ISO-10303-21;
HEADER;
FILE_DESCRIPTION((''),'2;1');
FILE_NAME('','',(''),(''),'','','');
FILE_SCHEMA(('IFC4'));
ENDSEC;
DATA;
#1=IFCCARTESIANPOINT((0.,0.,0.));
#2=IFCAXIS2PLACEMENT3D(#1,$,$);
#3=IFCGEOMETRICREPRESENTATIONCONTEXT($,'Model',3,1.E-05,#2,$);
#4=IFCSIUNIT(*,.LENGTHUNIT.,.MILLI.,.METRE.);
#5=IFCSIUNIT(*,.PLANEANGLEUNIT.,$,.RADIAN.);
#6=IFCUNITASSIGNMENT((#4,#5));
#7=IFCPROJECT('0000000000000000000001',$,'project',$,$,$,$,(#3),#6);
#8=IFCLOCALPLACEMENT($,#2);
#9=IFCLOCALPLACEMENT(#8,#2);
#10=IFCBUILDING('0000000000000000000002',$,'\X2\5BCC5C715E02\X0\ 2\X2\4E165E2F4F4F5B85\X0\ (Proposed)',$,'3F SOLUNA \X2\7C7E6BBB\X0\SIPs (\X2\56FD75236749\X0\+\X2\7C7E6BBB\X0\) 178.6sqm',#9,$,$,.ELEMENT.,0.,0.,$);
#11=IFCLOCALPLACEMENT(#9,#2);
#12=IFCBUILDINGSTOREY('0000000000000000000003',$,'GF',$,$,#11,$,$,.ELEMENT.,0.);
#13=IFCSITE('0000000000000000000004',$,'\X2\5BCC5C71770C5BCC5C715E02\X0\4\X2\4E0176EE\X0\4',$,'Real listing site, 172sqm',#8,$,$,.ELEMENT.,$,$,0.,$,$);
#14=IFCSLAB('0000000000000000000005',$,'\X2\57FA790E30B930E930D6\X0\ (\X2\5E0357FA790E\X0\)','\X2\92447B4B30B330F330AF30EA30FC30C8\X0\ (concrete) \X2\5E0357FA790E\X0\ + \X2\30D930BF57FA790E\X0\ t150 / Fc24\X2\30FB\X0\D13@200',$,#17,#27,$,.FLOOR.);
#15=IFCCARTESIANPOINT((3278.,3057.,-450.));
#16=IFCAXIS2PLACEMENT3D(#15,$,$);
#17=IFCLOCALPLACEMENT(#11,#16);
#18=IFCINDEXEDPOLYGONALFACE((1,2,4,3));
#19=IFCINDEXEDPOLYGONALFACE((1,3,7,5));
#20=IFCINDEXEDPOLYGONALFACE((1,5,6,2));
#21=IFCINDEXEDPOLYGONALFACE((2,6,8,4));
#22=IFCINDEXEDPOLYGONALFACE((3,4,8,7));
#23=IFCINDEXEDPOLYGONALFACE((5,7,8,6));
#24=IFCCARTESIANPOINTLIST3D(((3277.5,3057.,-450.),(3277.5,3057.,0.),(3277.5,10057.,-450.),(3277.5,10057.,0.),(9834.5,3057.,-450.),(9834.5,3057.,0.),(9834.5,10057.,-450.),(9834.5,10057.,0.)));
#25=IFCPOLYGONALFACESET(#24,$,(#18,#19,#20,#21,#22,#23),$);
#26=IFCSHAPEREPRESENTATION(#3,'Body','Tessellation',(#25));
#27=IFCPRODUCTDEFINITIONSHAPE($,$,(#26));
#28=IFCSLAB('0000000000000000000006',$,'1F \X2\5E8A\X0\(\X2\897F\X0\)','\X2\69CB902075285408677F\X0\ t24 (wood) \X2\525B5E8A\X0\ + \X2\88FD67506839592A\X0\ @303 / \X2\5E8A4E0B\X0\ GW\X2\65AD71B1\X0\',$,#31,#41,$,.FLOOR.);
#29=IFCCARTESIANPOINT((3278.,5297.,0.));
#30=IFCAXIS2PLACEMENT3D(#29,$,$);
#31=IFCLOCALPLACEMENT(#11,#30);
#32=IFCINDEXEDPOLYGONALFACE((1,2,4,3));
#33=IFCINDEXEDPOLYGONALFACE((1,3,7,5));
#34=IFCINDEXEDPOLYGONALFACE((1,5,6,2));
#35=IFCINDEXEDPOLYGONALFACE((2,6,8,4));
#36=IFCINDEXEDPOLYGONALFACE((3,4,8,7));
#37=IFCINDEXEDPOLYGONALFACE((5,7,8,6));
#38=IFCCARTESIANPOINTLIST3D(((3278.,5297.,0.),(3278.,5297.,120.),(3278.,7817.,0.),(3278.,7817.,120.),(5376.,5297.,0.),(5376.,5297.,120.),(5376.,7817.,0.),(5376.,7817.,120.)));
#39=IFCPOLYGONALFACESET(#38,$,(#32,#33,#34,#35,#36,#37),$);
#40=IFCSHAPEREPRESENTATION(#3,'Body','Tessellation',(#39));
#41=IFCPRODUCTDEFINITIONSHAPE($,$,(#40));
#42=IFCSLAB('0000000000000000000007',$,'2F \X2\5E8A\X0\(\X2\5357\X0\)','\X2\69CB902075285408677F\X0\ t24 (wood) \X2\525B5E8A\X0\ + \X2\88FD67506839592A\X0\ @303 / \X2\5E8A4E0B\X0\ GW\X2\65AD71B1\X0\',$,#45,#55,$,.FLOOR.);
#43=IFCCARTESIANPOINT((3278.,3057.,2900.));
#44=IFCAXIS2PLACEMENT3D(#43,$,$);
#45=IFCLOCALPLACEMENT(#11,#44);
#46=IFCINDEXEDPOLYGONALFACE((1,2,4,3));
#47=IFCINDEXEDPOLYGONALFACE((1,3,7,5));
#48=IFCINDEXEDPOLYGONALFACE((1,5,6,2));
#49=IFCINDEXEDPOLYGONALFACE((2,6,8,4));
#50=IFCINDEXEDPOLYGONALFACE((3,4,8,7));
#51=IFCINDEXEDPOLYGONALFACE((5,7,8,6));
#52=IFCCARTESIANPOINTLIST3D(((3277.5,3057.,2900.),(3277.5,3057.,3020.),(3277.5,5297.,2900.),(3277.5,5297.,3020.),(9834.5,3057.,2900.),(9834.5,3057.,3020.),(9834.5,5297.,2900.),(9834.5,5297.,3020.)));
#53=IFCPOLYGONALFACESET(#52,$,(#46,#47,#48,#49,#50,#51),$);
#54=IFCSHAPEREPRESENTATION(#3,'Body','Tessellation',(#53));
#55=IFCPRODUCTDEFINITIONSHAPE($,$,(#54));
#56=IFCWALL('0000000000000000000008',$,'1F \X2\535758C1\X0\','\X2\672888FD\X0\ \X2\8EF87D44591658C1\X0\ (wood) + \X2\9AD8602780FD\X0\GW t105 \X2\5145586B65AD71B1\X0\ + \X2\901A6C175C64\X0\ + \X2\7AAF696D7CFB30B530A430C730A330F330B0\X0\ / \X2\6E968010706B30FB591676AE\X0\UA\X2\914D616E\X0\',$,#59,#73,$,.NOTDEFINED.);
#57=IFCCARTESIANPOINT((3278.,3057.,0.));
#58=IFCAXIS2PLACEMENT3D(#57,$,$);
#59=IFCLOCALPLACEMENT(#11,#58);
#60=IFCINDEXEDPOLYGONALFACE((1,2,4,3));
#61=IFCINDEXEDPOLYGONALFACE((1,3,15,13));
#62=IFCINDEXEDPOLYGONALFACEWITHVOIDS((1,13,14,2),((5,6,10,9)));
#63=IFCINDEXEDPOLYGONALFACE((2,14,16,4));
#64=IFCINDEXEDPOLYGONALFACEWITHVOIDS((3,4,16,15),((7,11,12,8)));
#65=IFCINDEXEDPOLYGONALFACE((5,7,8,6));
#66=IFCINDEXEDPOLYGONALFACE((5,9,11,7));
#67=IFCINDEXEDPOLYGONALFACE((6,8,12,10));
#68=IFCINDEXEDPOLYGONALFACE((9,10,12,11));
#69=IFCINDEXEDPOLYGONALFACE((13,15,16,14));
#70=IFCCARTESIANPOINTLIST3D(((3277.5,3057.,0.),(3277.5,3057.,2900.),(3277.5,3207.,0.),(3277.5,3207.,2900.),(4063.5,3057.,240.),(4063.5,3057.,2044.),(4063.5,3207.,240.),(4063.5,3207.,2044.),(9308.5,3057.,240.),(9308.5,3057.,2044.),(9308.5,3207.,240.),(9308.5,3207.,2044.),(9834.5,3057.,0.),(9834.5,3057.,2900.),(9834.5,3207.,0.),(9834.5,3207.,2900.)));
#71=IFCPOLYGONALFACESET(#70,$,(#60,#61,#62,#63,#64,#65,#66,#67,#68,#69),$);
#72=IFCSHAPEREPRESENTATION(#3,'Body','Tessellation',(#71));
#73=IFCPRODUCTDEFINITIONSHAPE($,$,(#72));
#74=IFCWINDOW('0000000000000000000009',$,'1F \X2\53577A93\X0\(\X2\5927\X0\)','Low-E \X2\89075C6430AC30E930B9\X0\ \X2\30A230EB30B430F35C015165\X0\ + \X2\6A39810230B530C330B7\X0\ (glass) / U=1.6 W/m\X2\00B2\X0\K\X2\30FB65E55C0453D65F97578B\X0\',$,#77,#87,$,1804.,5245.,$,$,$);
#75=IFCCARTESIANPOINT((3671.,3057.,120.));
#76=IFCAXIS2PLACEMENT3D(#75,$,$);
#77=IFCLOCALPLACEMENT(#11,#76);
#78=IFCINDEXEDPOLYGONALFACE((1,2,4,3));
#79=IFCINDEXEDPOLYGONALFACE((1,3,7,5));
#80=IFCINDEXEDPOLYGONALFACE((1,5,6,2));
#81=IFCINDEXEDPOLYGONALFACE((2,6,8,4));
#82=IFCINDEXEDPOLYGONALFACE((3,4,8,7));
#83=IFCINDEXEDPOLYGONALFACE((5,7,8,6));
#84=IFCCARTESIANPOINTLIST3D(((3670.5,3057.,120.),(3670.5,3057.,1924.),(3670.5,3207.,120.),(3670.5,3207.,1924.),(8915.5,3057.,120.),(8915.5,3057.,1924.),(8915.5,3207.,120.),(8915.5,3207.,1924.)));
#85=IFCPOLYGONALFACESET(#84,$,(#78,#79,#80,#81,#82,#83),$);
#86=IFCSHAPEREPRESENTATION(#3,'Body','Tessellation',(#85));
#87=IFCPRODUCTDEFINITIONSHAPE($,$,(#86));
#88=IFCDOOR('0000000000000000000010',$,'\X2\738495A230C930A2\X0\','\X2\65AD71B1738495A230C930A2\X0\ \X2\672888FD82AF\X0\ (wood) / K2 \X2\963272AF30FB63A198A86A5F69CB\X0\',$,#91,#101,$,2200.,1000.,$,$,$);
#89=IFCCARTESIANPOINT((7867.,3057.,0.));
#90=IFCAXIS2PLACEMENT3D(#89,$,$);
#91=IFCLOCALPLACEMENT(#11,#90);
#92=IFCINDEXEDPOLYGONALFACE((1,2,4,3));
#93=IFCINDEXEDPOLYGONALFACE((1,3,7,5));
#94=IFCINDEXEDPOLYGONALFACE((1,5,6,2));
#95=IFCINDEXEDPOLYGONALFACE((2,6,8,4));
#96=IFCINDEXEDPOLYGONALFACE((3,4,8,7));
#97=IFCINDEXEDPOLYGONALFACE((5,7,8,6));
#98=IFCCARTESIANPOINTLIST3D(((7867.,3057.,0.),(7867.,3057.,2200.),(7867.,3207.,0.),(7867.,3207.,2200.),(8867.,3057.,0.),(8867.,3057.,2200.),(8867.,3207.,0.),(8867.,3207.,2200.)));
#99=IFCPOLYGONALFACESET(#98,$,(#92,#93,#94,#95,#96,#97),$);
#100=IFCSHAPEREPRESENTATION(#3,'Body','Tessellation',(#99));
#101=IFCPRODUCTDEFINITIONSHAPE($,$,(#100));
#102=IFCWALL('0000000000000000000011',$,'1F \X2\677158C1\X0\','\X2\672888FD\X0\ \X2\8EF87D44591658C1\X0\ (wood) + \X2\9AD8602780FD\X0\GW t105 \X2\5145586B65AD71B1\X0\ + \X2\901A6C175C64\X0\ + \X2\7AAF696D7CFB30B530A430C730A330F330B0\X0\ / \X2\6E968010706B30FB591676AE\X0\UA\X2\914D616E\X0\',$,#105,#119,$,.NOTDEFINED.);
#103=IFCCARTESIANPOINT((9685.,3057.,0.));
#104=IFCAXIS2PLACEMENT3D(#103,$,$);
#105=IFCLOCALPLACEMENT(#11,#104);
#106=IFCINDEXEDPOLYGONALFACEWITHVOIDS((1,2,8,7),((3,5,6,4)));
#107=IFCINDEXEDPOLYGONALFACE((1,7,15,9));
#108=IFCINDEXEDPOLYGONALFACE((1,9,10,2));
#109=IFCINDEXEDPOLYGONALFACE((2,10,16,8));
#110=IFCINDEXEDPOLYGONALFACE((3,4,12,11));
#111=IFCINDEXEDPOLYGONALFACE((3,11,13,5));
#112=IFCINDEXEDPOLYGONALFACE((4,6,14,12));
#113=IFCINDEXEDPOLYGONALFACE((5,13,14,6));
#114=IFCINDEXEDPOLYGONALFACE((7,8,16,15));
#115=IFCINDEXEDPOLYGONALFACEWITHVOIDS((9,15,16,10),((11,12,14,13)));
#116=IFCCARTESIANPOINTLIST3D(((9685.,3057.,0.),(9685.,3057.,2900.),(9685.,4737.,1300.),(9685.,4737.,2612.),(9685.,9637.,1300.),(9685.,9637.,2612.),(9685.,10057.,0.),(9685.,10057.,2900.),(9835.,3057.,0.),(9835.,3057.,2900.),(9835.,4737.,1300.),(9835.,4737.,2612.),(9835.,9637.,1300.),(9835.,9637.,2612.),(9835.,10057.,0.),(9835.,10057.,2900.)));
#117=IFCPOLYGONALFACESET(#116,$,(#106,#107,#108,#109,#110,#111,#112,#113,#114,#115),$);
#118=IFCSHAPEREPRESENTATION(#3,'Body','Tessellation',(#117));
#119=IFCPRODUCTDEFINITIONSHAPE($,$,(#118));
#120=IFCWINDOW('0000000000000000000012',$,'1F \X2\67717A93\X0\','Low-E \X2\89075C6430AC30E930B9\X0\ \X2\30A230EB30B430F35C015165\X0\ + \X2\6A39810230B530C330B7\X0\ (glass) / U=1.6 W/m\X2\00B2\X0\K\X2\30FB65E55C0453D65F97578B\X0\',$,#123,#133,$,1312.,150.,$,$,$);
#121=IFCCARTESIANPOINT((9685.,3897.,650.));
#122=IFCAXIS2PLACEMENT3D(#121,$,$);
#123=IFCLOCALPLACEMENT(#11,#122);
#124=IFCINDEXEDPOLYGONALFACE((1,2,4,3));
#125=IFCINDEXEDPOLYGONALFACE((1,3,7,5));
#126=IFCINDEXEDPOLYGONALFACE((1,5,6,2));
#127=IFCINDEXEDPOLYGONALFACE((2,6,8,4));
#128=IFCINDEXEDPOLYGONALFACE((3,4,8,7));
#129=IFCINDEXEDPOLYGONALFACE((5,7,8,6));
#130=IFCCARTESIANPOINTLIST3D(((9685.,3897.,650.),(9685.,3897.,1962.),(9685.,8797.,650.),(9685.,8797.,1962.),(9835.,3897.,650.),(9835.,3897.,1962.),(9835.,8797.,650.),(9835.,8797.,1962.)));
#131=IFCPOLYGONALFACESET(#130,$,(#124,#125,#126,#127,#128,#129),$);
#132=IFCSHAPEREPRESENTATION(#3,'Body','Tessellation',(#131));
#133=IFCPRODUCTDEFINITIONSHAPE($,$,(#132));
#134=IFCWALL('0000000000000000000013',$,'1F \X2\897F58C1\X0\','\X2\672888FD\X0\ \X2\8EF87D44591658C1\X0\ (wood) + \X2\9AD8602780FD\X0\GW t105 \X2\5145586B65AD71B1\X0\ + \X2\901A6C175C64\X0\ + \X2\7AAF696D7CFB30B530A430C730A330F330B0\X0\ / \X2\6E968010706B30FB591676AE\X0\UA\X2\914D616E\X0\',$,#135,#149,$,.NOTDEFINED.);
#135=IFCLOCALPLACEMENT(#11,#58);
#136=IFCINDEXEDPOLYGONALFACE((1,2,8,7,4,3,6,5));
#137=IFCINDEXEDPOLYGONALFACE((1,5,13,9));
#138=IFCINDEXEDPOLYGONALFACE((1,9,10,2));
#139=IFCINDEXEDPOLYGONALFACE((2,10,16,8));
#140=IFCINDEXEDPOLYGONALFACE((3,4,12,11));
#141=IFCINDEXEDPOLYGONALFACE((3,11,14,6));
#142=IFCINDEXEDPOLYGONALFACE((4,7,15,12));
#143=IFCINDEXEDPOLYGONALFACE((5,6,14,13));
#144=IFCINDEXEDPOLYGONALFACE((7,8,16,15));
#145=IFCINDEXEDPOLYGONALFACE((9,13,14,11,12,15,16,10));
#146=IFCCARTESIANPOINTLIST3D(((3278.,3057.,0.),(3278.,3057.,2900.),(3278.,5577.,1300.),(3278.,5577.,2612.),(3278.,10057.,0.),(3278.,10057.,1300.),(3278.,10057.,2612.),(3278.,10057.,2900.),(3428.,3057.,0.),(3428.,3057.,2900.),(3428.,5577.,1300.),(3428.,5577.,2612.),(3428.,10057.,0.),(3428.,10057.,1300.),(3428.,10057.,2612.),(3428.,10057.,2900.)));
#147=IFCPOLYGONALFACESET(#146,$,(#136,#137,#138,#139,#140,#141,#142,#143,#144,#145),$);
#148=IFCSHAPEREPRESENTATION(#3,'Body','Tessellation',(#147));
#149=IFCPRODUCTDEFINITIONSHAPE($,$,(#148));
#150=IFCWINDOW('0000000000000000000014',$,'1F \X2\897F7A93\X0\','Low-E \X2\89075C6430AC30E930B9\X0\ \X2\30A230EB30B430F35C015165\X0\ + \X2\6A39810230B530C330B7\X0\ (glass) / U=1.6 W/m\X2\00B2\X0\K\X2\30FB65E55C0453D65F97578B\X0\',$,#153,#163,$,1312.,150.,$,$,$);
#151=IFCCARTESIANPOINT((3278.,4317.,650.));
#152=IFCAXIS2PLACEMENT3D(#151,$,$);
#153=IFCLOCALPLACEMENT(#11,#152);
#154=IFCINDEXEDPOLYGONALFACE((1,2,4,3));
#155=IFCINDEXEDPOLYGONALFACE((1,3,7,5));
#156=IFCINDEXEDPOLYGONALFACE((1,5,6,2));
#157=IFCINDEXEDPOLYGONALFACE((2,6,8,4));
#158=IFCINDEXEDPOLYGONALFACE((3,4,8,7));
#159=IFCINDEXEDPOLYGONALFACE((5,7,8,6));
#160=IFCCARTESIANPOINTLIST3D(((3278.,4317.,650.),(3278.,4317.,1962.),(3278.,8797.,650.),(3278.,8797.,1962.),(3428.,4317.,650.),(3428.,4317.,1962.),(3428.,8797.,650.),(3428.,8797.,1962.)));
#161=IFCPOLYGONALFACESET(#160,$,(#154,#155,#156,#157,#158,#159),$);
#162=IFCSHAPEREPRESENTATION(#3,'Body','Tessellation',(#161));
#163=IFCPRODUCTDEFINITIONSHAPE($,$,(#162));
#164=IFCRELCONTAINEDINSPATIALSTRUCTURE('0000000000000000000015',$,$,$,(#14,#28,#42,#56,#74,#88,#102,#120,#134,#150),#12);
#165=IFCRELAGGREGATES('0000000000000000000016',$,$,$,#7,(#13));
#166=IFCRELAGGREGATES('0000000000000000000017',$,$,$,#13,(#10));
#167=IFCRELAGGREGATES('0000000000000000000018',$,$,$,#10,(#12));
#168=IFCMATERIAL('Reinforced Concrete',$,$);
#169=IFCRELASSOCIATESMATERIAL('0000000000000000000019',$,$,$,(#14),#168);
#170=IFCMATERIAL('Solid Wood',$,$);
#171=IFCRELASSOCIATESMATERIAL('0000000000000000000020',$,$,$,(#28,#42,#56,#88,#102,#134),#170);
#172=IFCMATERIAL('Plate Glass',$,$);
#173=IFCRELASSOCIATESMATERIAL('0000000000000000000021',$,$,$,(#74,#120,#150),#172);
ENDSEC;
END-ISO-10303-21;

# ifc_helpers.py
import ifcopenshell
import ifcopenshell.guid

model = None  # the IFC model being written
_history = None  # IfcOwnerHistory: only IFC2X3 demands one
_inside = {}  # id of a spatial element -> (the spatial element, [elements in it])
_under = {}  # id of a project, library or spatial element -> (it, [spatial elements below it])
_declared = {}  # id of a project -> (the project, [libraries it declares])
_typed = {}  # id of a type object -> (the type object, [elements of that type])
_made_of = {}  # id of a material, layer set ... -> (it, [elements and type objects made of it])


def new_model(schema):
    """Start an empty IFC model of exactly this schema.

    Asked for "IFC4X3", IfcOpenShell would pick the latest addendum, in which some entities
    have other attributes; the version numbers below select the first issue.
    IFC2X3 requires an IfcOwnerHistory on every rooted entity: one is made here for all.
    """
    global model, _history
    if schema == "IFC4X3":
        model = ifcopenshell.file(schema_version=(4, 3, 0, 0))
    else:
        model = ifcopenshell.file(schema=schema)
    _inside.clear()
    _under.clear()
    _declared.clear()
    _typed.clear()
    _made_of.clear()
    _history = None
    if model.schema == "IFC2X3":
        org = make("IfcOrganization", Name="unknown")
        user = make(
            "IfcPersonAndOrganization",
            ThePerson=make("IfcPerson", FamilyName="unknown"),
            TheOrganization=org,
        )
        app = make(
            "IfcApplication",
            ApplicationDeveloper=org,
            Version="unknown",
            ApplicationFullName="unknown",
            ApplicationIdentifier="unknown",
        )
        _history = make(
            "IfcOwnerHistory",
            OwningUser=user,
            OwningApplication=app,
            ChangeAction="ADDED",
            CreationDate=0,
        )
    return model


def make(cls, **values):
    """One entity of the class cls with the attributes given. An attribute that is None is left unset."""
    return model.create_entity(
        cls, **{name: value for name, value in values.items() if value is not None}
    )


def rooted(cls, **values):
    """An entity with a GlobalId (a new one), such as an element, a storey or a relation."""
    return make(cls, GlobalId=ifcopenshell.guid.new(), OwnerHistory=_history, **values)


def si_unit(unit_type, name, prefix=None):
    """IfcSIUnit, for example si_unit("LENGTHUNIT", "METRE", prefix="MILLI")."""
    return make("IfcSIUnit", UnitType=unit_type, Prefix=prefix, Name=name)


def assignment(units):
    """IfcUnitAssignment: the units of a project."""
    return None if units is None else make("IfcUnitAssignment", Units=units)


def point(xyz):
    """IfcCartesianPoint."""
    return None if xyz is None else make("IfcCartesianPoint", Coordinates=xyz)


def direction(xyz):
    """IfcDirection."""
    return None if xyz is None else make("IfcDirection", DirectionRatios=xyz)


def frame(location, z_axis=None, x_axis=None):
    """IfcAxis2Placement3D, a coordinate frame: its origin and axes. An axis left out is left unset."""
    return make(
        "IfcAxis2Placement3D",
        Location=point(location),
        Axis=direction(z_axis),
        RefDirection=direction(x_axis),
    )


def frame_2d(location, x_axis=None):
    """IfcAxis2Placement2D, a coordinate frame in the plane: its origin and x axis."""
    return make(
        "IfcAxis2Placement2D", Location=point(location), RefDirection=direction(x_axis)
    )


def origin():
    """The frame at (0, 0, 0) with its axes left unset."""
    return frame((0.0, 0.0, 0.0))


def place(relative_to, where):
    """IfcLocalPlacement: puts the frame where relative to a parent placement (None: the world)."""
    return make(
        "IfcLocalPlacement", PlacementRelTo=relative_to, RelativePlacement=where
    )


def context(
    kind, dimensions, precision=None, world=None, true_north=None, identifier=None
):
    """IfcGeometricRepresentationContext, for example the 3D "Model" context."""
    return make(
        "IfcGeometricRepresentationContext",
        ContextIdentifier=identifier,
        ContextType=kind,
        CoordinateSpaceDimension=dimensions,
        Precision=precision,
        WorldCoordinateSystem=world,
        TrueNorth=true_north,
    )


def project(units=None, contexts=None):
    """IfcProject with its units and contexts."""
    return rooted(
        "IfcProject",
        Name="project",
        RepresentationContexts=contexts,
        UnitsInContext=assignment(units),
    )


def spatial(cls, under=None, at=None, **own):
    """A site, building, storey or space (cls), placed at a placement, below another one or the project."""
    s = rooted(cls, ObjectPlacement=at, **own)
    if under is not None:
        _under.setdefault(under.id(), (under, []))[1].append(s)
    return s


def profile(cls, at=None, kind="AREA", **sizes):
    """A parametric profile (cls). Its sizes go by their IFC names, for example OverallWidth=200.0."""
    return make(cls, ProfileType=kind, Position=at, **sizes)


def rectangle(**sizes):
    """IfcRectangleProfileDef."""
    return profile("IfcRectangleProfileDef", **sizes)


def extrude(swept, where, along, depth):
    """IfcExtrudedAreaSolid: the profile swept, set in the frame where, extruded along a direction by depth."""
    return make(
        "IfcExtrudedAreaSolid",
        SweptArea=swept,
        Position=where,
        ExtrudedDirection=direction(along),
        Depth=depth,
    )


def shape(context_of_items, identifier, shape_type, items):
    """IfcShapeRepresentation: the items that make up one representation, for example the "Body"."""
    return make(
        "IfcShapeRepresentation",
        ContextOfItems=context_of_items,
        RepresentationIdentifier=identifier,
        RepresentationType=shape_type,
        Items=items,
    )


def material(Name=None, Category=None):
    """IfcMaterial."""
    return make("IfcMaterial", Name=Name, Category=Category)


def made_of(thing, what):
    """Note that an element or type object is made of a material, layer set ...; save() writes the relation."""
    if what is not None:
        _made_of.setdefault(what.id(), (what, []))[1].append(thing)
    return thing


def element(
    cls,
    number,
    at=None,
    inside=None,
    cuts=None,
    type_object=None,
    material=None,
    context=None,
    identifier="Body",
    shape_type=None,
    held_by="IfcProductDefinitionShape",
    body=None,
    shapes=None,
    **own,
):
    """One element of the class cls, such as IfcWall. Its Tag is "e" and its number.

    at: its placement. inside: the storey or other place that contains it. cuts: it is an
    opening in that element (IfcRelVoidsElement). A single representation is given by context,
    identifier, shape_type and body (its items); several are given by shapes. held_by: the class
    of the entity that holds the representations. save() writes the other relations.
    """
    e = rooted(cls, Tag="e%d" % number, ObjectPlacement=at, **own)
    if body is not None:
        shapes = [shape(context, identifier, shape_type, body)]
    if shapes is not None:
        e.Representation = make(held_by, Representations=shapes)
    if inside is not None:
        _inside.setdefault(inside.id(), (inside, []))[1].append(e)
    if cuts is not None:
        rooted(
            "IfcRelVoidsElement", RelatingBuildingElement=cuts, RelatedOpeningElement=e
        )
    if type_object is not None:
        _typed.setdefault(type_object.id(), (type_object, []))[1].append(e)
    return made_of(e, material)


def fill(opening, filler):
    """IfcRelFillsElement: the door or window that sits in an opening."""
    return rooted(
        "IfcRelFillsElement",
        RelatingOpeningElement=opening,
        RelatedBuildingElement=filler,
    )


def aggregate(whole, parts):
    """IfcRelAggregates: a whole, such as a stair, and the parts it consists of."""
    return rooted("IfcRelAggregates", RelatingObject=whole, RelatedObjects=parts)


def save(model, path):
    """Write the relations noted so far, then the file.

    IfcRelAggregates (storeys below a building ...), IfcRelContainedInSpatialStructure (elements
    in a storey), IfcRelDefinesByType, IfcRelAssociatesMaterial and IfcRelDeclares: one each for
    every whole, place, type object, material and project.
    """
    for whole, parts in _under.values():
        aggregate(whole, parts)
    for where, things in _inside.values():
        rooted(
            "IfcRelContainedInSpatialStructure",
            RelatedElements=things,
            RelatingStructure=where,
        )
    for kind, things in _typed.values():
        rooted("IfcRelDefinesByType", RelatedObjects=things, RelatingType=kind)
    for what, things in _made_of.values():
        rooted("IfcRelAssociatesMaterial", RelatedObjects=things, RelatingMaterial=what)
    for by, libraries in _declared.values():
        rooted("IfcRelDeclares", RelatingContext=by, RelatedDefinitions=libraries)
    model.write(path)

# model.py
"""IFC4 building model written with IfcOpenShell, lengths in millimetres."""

from ifc_helpers import new_model, si_unit, frame, frame_2d, origin, place, context, project, spatial, rectangle, extrude, material, element, fill, save


model = new_model("IFC4")

# Units and contexts
model_context = context("Model", 3, precision=1e-05, world=origin())
ifc_project = project(units=[si_unit("LENGTHUNIT", "METRE", prefix="MILLI"), si_unit("PLANEANGLEUNIT", "RADIAN")], contexts=[model_context])

# Site, building, storey
site_placement = place(None, origin())
site = spatial("IfcSite", under=ifc_project, at=site_placement, Name="富山県富山市4丁目4", ObjectType="Real listing site, 172sqm", CompositionType="ELEMENT", RefElevation=0.0)
building_placement = place(site_placement, origin())
building = spatial("IfcBuilding", under=site, at=building_placement, Name="富山市 2世帯住宅 (Proposed)", ObjectType="3F SOLUNA 籾殻SIPs (国産杉+籾殻) 178.6sqm", CompositionType="ELEMENT", ElevationOfRefHeight=0.0, ElevationOfTerrain=0.0)
storey_placement = place(building_placement, origin())
storey = spatial("IfcBuildingStorey", under=building, at=storey_placement, Name="GF", CompositionType="ELEMENT", Elevation=0.0)

# Slabs
ifc_material_1 = material(Name="Reinforced Concrete")
slab_1_placement = place(storey_placement, frame((3278.0, 3057.0, -450.0)))
element("IfcSlab", 1, at=slab_1_placement, inside=storey, material=ifc_material_1, Name="基礎スラブ (布基礎)", Description="鉄筋コンクリート (concrete) 布基礎 + ベタ基礎 t150 / Fc24・D13@200", PredefinedType="FLOOR", context=model_context, shape_type="SweptSolid", body=[
    extrude(rectangle(XDim=6557.0, YDim=7000.0, at=frame_2d((3278.0, 3500.0))), frame((3278.0, 3057.0, -450.0)), (0.0, 0.0, 1.0), 450.0),
])
ifc_material_2 = material(Name="Solid Wood")
slab_2_placement = place(storey_placement, frame((3278.0, 5297.0, 0.0)))
element("IfcSlab", 2, at=slab_2_placement, inside=storey, material=ifc_material_2, Name="1F 床(西)", Description="構造用合板 t24 (wood) 剛床 + 製材根太 @303 / 床下 GW断熱", PredefinedType="FLOOR", context=model_context, shape_type="SweptSolid", body=[
    extrude(rectangle(XDim=2098.0, YDim=2520.0, at=frame_2d((1049.0, 1260.0))), frame((3278.0, 5297.0, 0.0)), (0.0, 0.0, 1.0), 120.0),
])
slab_3_placement = place(storey_placement, frame((3278.0, 3057.0, 2900.0)))
element("IfcSlab", 3, at=slab_3_placement, inside=storey, material=ifc_material_2, Name="2F 床(南)", Description="構造用合板 t24 (wood) 剛床 + 製材根太 @303 / 床下 GW断熱", PredefinedType="FLOOR", context=model_context, shape_type="SweptSolid", body=[
    extrude(rectangle(XDim=6557.0, YDim=2240.0, at=frame_2d((3278.0, 1120.0))), frame((3278.0, 3057.0, 2900.0)), (0.0, 0.0, 1.0), 120.0),
])

# Wall, openings, window, door
wall_1_placement = place(storey_placement, frame((3278.0, 3057.0, 0.0)))
wall_1 = element("IfcWall", 4, at=wall_1_placement, inside=storey, material=ifc_material_2, Name="1F 南壁", Description="木製 軸組外壁 (wood) + 高性能GW t105 充填断熱 + 通気層 + 窯業系サイディング / 準耐火・外皮UA配慮", PredefinedType="NOTDEFINED", context=model_context, shape_type="SweptSolid", body=[
    extrude(rectangle(XDim=6557.0, YDim=150.0, at=frame_2d((3278.0, 75.0))), frame((3278.0, 3057.0, 0.0)), (0.0, 0.0, 1.0), 2900.0),
])
opening_1_placement = place(storey_placement, frame((3671.0, 3057.0, 120.0)))
opening_1 = element("IfcOpeningElement", 5, at=opening_1_placement, cuts=wall_1, PredefinedType="NOTDEFINED", context=model_context, shape_type="SweptSolid", body=[
    extrude(rectangle(XDim=5245.0, YDim=150.0, at=frame_2d((2622.0, 75.0))), frame((3671.0, 3057.0, 120.0)), (0.0, 0.0, 1.0), 1804.0),
])
opening_2_placement = place(storey_placement, frame((7867.0, 3057.0, 0.0)))
opening_2 = element("IfcOpeningElement", 6, at=opening_2_placement, cuts=wall_1, PredefinedType="NOTDEFINED", context=model_context, shape_type="SweptSolid", body=[
    extrude(rectangle(XDim=1000.0, YDim=150.0, at=frame_2d((500.0, 75.0))), frame((7867.0, 3057.0, 0.0)), (0.0, 0.0, 1.0), 2200.0),
])
ifc_material_3 = material(Name="Plate Glass")
window_1_placement = place(storey_placement, frame((3671.0, 3057.0, 120.0)))
window_1 = element("IfcWindow", 7, at=window_1_placement, inside=storey, material=ifc_material_3, Name="1F 南窓(大)", Description="Low-E 複層ガラス アルゴン封入 + 樹脂サッシ (glass) / U=1.6 W/m²K・日射取得型", OverallHeight=1804.0, OverallWidth=5245.0, context=model_context, shape_type="SweptSolid", body=[
    extrude(rectangle(XDim=5245.0, YDim=150.0, at=frame_2d((2622.0, 75.0))), frame((3671.0, 3057.0, 120.0)), (0.0, 0.0, 1.0), 1804.0),
])
fill(opening_1, window_1)
door_placement = place(storey_placement, frame((7867.0, 3057.0, 0.0)))
door = element("IfcDoor", 8, at=door_placement, inside=storey, material=ifc_material_2, Name="玄関ドア", Description="断熱玄関ドア 木製芯 (wood) / K2 防犯・採風機構", OverallHeight=2200.0, OverallWidth=1000.0, context=model_context, shape_type="SweptSolid", body=[
    extrude(rectangle(XDim=1000.0, YDim=150.0, at=frame_2d((500.0, 75.0))), frame((7867.0, 3057.0, 0.0)), (0.0, 0.0, 1.0), 2200.0),
])
fill(opening_2, door)

# Walls, openings, windows
wall_2_placement = place(storey_placement, frame((9685.0, 3057.0, 0.0)))
wall_2 = element("IfcWall", 9, at=wall_2_placement, inside=storey, material=ifc_material_2, Name="1F 東壁", Description="木製 軸組外壁 (wood) + 高性能GW t105 充填断熱 + 通気層 + 窯業系サイディング / 準耐火・外皮UA配慮", PredefinedType="NOTDEFINED", context=model_context, shape_type="SweptSolid", body=[
    extrude(rectangle(XDim=150.0, YDim=7000.0, at=frame_2d((75.0, 3500.0))), frame((9685.0, 3057.0, 0.0)), (0.0, 0.0, 1.0), 2900.0),
])
opening_3_placement = place(storey_placement, frame((9685.0, 3897.0, 650.0)))
opening_3 = element("IfcOpeningElement", 10, at=opening_3_placement, cuts=wall_2, PredefinedType="NOTDEFINED", context=model_context, shape_type="SweptSolid", body=[
    extrude(rectangle(XDim=150.0, YDim=4900.0, at=frame_2d((75.0, 2450.0))), frame((9685.0, 3897.0, 650.0)), (0.0, 0.0, 1.0), 1312.0),
])
window_2_placement = place(storey_placement, frame((9685.0, 3897.0, 650.0)))
window_2 = element("IfcWindow", 11, at=window_2_placement, inside=storey, material=ifc_material_3, Name="1F 東窓", Description="Low-E 複層ガラス アルゴン封入 + 樹脂サッシ (glass) / U=1.6 W/m²K・日射取得型", OverallHeight=1312.0, OverallWidth=150.0, context=model_context, shape_type="SweptSolid", body=[
    extrude(rectangle(XDim=150.0, YDim=4900.0, at=frame_2d((75.0, 2450.0))), frame((9685.0, 3897.0, 650.0)), (0.0, 0.0, 1.0), 1312.0),
])
fill(opening_3, window_2)
wall_3_placement = place(storey_placement, frame((3278.0, 3057.0, 0.0)))
wall_3 = element("IfcWall", 12, at=wall_3_placement, inside=storey, material=ifc_material_2, Name="1F 西壁", Description="木製 軸組外壁 (wood) + 高性能GW t105 充填断熱 + 通気層 + 窯業系サイディング / 準耐火・外皮UA配慮", PredefinedType="NOTDEFINED", context=model_context, shape_type="SweptSolid", body=[
    extrude(rectangle(XDim=150.0, YDim=7000.0, at=frame_2d((75.0, 3500.0))), frame((3278.0, 3057.0, 0.0)), (0.0, 0.0, 1.0), 2900.0),
])
opening_4_placement = place(storey_placement, frame((3278.0, 4317.0, 650.0)))
opening_4 = element("IfcOpeningElement", 13, at=opening_4_placement, cuts=wall_3, PredefinedType="NOTDEFINED", context=model_context, shape_type="SweptSolid", body=[
    extrude(rectangle(XDim=150.0, YDim=4480.0, at=frame_2d((75.0, 2240.0))), frame((3278.0, 4317.0, 650.0)), (0.0, 0.0, 1.0), 1312.0),
])
window_3_placement = place(storey_placement, frame((3278.0, 4317.0, 650.0)))
window_3 = element("IfcWindow", 14, at=window_3_placement, inside=storey, material=ifc_material_3, Name="1F 西窓", Description="Low-E 複層ガラス アルゴン封入 + 樹脂サッシ (glass) / U=1.6 W/m²K・日射取得型", OverallHeight=1312.0, OverallWidth=150.0, context=model_context, shape_type="SweptSolid", body=[
    extrude(rectangle(XDim=150.0, YDim=4480.0, at=frame_2d((75.0, 2240.0))), frame((3278.0, 4317.0, 650.0)), (0.0, 0.0, 1.0), 1312.0),
])
fill(opening_4, window_3)

save(model, "model.ifc")
